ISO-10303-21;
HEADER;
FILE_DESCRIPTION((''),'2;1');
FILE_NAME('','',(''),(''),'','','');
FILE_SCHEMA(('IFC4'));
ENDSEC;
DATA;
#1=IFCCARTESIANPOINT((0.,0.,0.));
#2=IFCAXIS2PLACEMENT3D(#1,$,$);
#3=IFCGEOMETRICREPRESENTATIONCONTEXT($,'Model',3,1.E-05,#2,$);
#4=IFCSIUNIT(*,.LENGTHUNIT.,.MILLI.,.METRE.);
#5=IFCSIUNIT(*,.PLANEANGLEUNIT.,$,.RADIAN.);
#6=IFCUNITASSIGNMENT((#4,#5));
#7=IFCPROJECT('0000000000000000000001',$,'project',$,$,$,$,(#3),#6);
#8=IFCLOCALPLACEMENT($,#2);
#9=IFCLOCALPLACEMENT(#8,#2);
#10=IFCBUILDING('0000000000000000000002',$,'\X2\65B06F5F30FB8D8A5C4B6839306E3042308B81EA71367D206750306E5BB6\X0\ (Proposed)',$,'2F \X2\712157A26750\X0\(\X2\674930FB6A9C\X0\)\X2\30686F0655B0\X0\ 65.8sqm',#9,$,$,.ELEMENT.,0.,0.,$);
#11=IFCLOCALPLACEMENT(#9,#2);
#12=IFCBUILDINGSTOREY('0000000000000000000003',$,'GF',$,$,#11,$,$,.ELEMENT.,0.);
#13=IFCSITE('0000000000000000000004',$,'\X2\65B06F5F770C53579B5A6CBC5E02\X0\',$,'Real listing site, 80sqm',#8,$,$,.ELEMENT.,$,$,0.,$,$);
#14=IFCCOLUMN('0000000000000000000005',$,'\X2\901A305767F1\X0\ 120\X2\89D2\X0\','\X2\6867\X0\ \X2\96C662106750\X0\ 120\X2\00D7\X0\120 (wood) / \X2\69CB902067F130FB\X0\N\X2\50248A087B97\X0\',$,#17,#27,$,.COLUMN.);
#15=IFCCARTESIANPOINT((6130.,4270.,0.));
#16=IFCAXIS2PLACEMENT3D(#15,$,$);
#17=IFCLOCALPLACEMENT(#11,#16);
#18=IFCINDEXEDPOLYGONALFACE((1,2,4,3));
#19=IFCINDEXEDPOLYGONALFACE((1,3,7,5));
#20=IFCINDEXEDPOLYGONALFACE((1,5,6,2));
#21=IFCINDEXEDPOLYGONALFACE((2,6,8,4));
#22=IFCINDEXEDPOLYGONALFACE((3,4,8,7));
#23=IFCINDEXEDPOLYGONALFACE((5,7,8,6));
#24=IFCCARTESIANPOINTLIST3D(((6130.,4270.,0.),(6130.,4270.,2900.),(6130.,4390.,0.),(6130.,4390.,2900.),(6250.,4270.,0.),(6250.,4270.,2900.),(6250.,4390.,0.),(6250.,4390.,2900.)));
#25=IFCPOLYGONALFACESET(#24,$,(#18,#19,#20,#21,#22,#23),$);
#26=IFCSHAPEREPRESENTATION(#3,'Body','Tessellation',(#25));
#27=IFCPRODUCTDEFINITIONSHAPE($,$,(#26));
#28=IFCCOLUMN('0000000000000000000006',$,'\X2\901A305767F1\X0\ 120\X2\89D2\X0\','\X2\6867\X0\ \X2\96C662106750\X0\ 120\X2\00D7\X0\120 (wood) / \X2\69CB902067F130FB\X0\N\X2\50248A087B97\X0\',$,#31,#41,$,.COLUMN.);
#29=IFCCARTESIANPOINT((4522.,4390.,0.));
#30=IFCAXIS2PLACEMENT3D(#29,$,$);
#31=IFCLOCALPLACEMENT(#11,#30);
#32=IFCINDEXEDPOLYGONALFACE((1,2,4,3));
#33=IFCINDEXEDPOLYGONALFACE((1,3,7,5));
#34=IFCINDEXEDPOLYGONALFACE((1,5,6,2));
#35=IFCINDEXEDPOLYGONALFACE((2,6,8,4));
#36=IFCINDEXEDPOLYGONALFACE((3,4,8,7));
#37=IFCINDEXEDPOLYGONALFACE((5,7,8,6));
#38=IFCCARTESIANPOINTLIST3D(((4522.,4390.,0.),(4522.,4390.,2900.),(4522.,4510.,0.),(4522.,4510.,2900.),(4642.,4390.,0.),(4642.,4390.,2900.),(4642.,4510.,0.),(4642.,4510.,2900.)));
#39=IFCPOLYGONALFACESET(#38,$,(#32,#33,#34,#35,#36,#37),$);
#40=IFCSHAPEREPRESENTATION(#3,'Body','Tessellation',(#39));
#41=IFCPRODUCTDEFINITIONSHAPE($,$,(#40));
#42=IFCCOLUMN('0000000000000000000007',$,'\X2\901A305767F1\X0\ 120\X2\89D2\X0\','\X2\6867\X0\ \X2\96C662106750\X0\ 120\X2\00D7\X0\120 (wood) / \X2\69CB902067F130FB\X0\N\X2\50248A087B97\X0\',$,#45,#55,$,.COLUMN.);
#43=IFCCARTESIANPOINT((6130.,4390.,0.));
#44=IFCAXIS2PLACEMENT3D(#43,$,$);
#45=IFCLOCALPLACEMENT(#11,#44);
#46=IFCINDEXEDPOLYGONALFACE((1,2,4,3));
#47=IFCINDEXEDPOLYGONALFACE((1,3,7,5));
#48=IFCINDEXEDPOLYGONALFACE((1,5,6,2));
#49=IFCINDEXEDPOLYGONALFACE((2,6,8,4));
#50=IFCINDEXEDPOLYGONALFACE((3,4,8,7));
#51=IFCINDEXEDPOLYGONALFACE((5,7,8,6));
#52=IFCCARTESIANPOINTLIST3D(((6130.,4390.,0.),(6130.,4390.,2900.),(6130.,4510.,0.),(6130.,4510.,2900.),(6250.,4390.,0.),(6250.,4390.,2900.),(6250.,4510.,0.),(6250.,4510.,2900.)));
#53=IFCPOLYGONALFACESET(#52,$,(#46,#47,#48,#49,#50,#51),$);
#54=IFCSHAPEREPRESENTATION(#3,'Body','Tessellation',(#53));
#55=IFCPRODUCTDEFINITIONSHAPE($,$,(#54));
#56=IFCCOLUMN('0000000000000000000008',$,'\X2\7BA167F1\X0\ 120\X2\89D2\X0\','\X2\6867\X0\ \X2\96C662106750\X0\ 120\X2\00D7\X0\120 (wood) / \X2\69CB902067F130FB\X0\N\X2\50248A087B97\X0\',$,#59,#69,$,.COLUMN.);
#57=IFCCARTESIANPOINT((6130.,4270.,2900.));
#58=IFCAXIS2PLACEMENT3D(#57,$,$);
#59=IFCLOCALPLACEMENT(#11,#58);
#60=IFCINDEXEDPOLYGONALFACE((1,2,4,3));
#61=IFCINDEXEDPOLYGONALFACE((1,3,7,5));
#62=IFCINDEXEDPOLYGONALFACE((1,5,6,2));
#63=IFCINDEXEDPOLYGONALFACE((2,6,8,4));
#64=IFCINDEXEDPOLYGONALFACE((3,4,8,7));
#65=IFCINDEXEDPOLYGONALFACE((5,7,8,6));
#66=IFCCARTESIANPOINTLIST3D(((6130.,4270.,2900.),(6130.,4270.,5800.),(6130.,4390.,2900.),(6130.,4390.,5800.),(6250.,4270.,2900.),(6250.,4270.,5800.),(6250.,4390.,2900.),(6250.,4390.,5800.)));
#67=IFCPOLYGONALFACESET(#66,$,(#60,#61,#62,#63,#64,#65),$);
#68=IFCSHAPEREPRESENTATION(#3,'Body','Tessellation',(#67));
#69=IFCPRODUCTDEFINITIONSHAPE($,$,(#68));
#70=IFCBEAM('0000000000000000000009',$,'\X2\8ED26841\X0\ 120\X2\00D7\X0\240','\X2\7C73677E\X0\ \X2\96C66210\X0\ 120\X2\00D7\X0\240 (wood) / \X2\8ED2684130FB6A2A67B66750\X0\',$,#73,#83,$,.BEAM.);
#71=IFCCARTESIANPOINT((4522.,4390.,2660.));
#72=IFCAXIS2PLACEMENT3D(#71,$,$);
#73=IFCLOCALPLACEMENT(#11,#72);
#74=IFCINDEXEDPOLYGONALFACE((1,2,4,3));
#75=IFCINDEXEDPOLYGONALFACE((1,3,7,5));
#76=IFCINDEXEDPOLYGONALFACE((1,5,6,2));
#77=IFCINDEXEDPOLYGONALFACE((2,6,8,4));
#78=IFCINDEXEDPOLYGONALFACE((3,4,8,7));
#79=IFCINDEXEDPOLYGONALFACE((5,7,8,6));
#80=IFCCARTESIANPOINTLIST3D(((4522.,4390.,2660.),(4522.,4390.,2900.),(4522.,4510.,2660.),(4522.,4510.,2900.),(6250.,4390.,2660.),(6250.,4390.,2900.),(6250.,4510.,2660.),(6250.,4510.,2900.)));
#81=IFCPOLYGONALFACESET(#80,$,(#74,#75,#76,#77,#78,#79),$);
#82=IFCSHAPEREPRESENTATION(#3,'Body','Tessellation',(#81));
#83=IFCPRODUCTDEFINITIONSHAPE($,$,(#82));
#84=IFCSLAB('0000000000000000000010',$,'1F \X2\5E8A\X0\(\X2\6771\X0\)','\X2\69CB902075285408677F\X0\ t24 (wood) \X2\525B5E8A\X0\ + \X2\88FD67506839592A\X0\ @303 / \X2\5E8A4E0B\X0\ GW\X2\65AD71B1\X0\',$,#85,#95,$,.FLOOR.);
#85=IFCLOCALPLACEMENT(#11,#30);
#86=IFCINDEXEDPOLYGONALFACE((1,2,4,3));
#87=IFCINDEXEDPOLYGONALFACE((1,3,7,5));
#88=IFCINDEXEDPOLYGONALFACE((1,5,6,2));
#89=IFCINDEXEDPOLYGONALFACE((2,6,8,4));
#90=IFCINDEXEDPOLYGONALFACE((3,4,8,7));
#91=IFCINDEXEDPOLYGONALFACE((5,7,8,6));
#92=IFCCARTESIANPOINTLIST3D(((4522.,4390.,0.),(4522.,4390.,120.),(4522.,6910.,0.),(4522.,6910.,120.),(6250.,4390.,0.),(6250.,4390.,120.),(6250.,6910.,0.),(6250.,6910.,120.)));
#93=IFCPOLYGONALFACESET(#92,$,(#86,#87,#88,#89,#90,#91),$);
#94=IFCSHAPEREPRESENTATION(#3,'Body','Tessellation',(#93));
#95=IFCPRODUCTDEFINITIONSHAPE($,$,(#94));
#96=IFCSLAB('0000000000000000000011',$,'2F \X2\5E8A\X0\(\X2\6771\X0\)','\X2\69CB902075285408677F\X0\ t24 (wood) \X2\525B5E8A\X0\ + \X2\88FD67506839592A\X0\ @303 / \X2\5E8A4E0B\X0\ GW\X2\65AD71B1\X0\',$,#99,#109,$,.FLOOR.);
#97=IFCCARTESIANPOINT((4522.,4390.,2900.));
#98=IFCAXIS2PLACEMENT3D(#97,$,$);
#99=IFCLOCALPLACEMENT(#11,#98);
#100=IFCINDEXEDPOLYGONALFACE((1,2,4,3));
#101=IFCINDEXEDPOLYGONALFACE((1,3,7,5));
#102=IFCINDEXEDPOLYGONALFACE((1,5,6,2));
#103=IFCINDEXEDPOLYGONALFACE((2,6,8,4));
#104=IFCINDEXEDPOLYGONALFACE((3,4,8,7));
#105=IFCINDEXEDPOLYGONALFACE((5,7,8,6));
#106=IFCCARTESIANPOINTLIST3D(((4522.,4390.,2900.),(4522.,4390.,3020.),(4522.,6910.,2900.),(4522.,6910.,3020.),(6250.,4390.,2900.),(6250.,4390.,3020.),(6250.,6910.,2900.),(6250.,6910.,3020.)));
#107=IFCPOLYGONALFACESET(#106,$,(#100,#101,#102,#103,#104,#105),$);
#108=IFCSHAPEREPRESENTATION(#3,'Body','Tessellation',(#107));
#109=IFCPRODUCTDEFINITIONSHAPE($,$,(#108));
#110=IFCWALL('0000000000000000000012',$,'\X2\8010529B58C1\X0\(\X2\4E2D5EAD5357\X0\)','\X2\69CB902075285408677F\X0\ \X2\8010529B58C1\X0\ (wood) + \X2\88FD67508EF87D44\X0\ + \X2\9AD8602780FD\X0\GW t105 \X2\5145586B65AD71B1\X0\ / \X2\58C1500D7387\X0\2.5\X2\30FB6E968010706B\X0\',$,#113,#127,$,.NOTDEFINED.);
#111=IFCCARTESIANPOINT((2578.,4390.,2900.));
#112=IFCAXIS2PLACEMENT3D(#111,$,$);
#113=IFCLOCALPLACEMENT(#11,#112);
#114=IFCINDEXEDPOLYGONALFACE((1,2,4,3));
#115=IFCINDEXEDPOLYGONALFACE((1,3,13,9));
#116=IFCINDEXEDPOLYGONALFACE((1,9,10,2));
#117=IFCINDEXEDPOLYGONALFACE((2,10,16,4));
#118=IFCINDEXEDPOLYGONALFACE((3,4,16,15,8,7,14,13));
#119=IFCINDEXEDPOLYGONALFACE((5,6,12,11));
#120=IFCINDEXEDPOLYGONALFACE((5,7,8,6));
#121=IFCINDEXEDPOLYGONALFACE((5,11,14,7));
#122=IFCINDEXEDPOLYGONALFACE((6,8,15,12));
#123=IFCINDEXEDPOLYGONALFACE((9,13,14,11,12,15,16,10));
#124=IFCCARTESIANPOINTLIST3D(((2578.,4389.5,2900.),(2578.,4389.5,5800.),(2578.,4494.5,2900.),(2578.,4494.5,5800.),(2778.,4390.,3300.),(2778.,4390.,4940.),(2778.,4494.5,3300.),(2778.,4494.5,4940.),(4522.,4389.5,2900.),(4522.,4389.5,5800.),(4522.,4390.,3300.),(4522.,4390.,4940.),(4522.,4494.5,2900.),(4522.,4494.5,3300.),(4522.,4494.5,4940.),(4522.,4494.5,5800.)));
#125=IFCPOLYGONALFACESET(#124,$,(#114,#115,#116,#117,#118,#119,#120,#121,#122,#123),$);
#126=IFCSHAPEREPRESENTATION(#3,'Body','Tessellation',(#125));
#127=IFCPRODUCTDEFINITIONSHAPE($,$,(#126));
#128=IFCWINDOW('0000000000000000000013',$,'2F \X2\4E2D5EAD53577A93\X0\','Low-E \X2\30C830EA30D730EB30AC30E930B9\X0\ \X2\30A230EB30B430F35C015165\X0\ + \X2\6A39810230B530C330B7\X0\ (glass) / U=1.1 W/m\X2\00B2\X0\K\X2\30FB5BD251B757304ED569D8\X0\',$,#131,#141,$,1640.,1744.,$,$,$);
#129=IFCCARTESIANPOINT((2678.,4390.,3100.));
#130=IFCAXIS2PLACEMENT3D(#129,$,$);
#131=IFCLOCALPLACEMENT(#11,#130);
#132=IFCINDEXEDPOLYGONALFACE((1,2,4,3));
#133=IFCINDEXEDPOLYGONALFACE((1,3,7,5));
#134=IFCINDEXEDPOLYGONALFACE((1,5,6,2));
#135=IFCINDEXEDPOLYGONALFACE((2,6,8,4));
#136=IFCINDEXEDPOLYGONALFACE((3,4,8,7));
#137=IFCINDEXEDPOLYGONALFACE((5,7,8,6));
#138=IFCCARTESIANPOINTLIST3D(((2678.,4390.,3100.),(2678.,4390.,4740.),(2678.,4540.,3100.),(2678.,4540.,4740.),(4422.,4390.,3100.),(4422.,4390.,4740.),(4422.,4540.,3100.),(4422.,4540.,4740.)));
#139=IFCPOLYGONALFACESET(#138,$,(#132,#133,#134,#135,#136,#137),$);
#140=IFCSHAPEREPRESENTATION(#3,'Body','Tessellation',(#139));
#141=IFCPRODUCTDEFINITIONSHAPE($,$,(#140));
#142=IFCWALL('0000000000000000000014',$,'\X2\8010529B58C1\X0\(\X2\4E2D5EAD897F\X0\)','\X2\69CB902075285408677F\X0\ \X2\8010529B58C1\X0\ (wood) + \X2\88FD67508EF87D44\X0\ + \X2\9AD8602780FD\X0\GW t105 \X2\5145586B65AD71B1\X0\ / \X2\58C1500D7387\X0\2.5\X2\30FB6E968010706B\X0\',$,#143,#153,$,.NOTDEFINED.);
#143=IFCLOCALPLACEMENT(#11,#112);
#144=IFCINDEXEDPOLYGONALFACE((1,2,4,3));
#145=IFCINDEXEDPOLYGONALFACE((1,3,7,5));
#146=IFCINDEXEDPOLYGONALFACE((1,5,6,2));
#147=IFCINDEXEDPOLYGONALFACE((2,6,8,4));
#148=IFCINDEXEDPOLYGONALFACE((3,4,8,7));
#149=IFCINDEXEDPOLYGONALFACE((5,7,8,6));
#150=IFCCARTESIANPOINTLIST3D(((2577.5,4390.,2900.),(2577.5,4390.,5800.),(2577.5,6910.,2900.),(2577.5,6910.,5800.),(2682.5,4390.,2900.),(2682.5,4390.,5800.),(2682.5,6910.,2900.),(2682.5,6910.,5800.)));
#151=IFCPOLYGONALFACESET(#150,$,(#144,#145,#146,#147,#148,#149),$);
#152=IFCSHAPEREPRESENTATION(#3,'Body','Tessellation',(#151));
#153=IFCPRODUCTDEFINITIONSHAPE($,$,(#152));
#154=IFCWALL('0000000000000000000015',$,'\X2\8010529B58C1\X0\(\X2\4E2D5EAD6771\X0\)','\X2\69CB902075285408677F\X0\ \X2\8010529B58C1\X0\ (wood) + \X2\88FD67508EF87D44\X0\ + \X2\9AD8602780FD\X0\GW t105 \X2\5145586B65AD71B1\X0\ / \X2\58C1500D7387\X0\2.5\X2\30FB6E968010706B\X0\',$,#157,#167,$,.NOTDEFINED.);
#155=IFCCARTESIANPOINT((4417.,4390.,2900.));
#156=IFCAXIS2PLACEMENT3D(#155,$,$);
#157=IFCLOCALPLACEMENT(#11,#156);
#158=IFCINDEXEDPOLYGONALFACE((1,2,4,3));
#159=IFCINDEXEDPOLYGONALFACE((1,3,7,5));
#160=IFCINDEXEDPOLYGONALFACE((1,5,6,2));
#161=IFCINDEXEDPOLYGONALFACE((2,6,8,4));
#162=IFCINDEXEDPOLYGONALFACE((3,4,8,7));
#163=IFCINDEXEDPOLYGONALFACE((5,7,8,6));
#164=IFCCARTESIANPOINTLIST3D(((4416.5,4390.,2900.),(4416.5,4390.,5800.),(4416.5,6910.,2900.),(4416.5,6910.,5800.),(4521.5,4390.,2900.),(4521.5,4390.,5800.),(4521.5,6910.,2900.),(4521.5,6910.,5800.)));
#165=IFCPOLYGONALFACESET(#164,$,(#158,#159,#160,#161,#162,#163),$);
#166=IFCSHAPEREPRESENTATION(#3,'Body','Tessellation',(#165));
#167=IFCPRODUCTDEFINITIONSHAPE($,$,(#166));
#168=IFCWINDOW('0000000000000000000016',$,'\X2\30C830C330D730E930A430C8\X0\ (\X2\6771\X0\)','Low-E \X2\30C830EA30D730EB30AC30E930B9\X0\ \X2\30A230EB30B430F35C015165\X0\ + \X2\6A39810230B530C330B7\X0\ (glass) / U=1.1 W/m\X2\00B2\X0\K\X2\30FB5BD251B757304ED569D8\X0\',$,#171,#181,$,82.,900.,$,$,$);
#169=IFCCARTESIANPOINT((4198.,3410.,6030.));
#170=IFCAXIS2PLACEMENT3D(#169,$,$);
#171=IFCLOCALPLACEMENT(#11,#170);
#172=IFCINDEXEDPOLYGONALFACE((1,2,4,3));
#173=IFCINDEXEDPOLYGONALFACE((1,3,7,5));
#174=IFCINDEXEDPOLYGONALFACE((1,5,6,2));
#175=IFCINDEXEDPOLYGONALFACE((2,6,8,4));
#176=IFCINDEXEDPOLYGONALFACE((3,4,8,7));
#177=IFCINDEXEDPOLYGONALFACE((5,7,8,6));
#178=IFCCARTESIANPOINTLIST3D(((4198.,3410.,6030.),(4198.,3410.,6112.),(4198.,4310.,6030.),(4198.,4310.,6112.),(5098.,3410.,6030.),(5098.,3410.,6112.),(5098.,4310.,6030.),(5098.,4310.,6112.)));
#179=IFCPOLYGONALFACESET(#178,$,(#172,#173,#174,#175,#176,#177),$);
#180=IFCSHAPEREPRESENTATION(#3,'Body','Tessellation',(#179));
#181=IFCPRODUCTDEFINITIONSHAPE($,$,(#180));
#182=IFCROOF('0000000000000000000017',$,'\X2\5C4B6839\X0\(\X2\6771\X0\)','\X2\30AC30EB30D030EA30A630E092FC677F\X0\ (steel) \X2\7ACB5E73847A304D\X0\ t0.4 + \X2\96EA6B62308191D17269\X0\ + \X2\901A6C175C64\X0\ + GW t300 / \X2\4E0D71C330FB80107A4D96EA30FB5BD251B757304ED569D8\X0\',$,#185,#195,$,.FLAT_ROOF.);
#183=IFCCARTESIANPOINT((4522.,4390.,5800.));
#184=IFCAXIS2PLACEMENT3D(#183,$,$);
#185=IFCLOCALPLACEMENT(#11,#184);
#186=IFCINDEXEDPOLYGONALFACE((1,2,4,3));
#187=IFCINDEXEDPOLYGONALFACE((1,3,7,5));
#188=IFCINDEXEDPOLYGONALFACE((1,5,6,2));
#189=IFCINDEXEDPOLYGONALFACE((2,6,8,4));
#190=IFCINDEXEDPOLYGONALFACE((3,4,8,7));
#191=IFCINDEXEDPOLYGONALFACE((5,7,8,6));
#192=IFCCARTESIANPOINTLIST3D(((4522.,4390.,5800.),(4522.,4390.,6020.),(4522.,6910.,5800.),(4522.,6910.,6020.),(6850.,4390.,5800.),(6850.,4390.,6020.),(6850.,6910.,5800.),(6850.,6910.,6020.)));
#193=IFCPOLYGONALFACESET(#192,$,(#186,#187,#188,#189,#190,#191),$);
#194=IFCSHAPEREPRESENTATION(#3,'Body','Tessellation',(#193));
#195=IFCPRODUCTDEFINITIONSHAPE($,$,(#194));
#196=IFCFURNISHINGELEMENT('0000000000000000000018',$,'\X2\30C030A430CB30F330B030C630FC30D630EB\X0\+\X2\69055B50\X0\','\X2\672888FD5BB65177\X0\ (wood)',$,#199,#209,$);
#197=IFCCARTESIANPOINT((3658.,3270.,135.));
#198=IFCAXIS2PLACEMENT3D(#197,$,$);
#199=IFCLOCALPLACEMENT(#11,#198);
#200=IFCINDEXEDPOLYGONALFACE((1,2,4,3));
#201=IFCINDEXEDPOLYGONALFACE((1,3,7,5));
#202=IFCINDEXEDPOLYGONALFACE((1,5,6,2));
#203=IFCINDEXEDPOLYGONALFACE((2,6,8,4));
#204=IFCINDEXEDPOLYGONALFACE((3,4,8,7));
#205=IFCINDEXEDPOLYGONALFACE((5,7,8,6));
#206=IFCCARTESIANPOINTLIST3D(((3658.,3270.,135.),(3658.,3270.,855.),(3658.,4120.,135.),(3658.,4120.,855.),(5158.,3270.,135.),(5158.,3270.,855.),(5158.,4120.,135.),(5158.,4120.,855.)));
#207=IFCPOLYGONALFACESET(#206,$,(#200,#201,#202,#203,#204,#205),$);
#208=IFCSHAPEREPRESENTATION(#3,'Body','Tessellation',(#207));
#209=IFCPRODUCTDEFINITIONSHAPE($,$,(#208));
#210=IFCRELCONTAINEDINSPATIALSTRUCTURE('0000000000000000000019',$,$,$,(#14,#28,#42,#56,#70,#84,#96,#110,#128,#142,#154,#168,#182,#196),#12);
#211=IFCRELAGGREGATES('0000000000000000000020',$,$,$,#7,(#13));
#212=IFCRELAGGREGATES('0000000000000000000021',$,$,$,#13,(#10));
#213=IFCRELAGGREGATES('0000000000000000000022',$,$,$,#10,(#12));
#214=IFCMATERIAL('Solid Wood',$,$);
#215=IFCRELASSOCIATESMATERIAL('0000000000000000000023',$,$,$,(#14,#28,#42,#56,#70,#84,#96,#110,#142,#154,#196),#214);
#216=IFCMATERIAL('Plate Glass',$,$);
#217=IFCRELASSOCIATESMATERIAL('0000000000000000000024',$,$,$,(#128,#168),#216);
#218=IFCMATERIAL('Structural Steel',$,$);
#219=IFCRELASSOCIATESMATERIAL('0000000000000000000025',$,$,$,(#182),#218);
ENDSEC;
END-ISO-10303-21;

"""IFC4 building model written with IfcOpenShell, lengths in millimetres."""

from ifc_helpers import new_model, si_unit, frame, frame_2d, origin, place, context, project, spatial, rectangle, extrude, material, element, fill, save


model = new_model("IFC4")

# Units and contexts
model_context = context("Model", 3, precision=1e-05, world=origin())
ifc_project = project(units=[si_unit("LENGTHUNIT", "METRE", prefix="MILLI"), si_unit("PLANEANGLEUNIT", "RADIAN")], contexts=[model_context])

# Site, building, storey
site_placement = place(None, origin())
site = spatial("IfcSite", under=ifc_project, at=site_placement, Name="新潟県南魚沼市", ObjectType="Real listing site, 80sqm", CompositionType="ELEMENT", RefElevation=0.0)
building_placement = place(site_placement, origin())
building = spatial("IfcBuilding", under=site, at=building_placement, Name="新潟・越屋根のある自然素材の家 (Proposed)", ObjectType="2F 無垢材(杉・檜)と漆喰 65.8sqm", CompositionType="ELEMENT", ElevationOfRefHeight=0.0, ElevationOfTerrain=0.0)
storey_placement = place(building_placement, origin())
storey = spatial("IfcBuildingStorey", under=building, at=storey_placement, Name="GF", CompositionType="ELEMENT", Elevation=0.0)

# Columns
ifc_material_1 = material(Name="Solid Wood")
column_1_placement = place(storey_placement, frame((6130.0, 4270.0, 0.0)))
element("IfcColumn", 1, at=column_1_placement, inside=storey, material=ifc_material_1, Name="通し柱 120角", Description="桧 集成材 120×120 (wood) / 構造柱・N値計算", PredefinedType="COLUMN", context=model_context, shape_type="SweptSolid", body=[
    extrude(rectangle(XDim=120.0, YDim=120.0, at=frame_2d((60.0, 60.0))), frame((6130.0, 4270.0, 0.0)), (0.0, 0.0, 1.0), 2900.0),
])
column_2_placement = place(storey_placement, frame((4522.0, 4390.0, 0.0)))
element("IfcColumn", 2, at=column_2_placement, inside=storey, material=ifc_material_1, Name="通し柱 120角", Description="桧 集成材 120×120 (wood) / 構造柱・N値計算", PredefinedType="COLUMN", context=model_context, shape_type="SweptSolid", body=[
    extrude(rectangle(XDim=120.0, YDim=120.0, at=frame_2d((60.0, 60.0))), frame((4522.0, 4390.0, 0.0)), (0.0, 0.0, 1.0), 2900.0),
])
column_3_placement = place(storey_placement, frame((6130.0, 4390.0, 0.0)))
element("IfcColumn", 3, at=column_3_placement, inside=storey, material=ifc_material_1, Name="通し柱 120角", Description="桧 集成材 120×120 (wood) / 構造柱・N値計算", PredefinedType="COLUMN", context=model_context, shape_type="SweptSolid", body=[
    extrude(rectangle(XDim=120.0, YDim=120.0, at=frame_2d((60.0, 60.0))), frame((6130.0, 4390.0, 0.0)), (0.0, 0.0, 1.0), 2900.0),
])
column_4_placement = place(storey_placement, frame((6130.0, 4270.0, 2900.0)))
element("IfcColumn", 4, at=column_4_placement, inside=storey, material=ifc_material_1, Name="管柱 120角", Description="桧 集成材 120×120 (wood) / 構造柱・N値計算", PredefinedType="COLUMN", context=model_context, shape_type="SweptSolid", body=[
    extrude(rectangle(XDim=120.0, YDim=120.0, at=frame_2d((60.0, 60.0))), frame((6130.0, 4270.0, 2900.0)), (0.0, 0.0, 1.0), 2900.0),
])

# Beam
beam_1_placement = place(storey_placement, frame((4522.0, 4390.0, 2660.0)))
element("IfcBeam", 5, at=beam_1_placement, inside=storey, material=ifc_material_1, Name="軒桁 120×240", Description="米松 集成 120×240 (wood) / 軒桁・横架材", PredefinedType="BEAM", context=model_context, shape_type="SweptSolid", body=[
    extrude(rectangle(XDim=1728.0, YDim=120.0, at=frame_2d((864.0, 60.0))), frame((4522.0, 4390.0, 2660.0)), (0.0, 0.0, 1.0), 240.0),
])

# Slabs
slab_1_placement = place(storey_placement, frame((4522.0, 4390.0, 0.0)))
element("IfcSlab", 6, at=slab_1_placement, inside=storey, material=ifc_material_1, Name="1F 床(東)", Description="構造用合板 t24 (wood) 剛床 + 製材根太 @303 / 床下 GW断熱", PredefinedType="FLOOR", context=model_context, shape_type="SweptSolid", body=[
    extrude(rectangle(XDim=1728.0, YDim=2520.0, at=frame_2d((864.0, 1260.0))), frame((4522.0, 4390.0, 0.0)), (0.0, 0.0, 1.0), 120.0),
])
slab_2_placement = place(storey_placement, frame((4522.0, 4390.0, 2900.0)))
element("IfcSlab", 7, at=slab_2_placement, inside=storey, material=ifc_material_1, Name="2F 床(東)", Description="構造用合板 t24 (wood) 剛床 + 製材根太 @303 / 床下 GW断熱", PredefinedType="FLOOR", context=model_context, shape_type="SweptSolid", body=[
    extrude(rectangle(XDim=1728.0, YDim=2520.0, at=frame_2d((864.0, 1260.0))), frame((4522.0, 4390.0, 2900.0)), (0.0, 0.0, 1.0), 120.0),
])

# Wall, opening, window
wall_1_placement = place(storey_placement, frame((2578.0, 4390.0, 2900.0)))
wall_1 = element("IfcWall", 8, at=wall_1_placement, inside=storey, material=ifc_material_1, Name="耐力壁(中庭南)", Description="構造用合板 耐力壁 (wood) + 製材軸組 + 高性能GW t105 充填断熱 / 壁倍率2.5・準耐火", PredefinedType="NOTDEFINED", context=model_context, shape_type="SweptSolid", body=[
    extrude(rectangle(XDim=1944.0, YDim=105.0, at=frame_2d((972.0, 52.0))), frame((2578.0, 4390.0, 2900.0)), (0.0, 0.0, 1.0), 2900.0),
])
opening_placement = place(storey_placement, frame((2678.0, 4390.0, 3100.0)))
opening = element("IfcOpeningElement", 9, at=opening_placement, cuts=wall_1, PredefinedType="NOTDEFINED", context=model_context, shape_type="SweptSolid", body=[
    extrude(rectangle(XDim=1744.0, YDim=150.0, at=frame_2d((872.0, 75.0))), frame((2678.0, 4390.0, 3100.0)), (0.0, 0.0, 1.0), 1640.0),
])
ifc_material_2 = material(Name="Plate Glass")
window_1_placement = place(storey_placement, frame((2678.0, 4390.0, 3100.0)))
window_1 = element("IfcWindow", 10, at=window_1_placement, inside=storey, material=ifc_material_2, Name="2F 中庭南窓", Description="Low-E トリプルガラス アルゴン封入 + 樹脂サッシ (glass) / U=1.1 W/m²K・寒冷地仕様", OverallHeight=1640.0, OverallWidth=1744.0, context=model_context, shape_type="SweptSolid", body=[
    extrude(rectangle(XDim=1744.0, YDim=150.0, at=frame_2d((872.0, 75.0))), frame((2678.0, 4390.0, 3100.0)), (0.0, 0.0, 1.0), 1640.0),
])
fill(opening, window_1)

# Walls
wall_2_placement = place(storey_placement, frame((2578.0, 4390.0, 2900.0)))
element("IfcWall", 11, at=wall_2_placement, inside=storey, material=ifc_material_1, Name="耐力壁(中庭西)", Description="構造用合板 耐力壁 (wood) + 製材軸組 + 高性能GW t105 充填断熱 / 壁倍率2.5・準耐火", PredefinedType="NOTDEFINED", context=model_context, shape_type="SweptSolid", body=[
    extrude(rectangle(XDim=105.0, YDim=2520.0, at=frame_2d((52.0, 1260.0))), frame((2578.0, 4390.0, 2900.0)), (0.0, 0.0, 1.0), 2900.0),
])
wall_3_placement = place(storey_placement, frame((4417.0, 4390.0, 2900.0)))
element("IfcWall", 12, at=wall_3_placement, inside=storey, material=ifc_material_1, Name="耐力壁(中庭東)", Description="構造用合板 耐力壁 (wood) + 製材軸組 + 高性能GW t105 充填断熱 / 壁倍率2.5・準耐火", PredefinedType="NOTDEFINED", context=model_context, shape_type="SweptSolid", body=[
    extrude(rectangle(XDim=105.0, YDim=2520.0, at=frame_2d((52.0, 1260.0))), frame((4417.0, 4390.0, 2900.0)), (0.0, 0.0, 1.0), 2900.0),
])

# Window
window_2_placement = place(storey_placement, frame((4198.0, 3410.0, 6030.0)))
element("IfcWindow", 13, at=window_2_placement, inside=storey, material=ifc_material_2, Name="トップライト (東)", Description="Low-E トリプルガラス アルゴン封入 + 樹脂サッシ (glass) / U=1.1 W/m²K・寒冷地仕様", OverallHeight=82.0, OverallWidth=900.0, context=model_context, shape_type="SweptSolid", body=[
    extrude(rectangle(XDim=900.0, YDim=900.0, at=frame_2d((450.0, 450.0))), frame((4198.0, 3410.0, 6030.0)), (0.0, 0.0, 1.0), 82.0),
])

# Roof
ifc_material_3 = material(Name="Structural Steel")
for number, where, name in (
    (14, (4522.0, 4390.0, 5800.0), "屋根(東)"),
):
    element("IfcRoof", number, at=place(storey_placement, frame(where)), inside=storey, material=ifc_material_3, Name=name, Description="ガルバリウム鋼板 (steel) 立平葺き t0.4 + 雪止め金物 + 通気層 + GW t300 / 不燃・耐積雪・寒冷地仕様", PredefinedType="FLAT_ROOF", context=model_context, shape_type="SweptSolid", body=[
        extrude(rectangle(XDim=2328.0, YDim=2520.0, at=frame_2d((1164.0, 1260.0))), frame((4522.0, 4390.0, 5800.0)), (0.0, 0.0, 1.0), 220.0),
    ])

# Furnishing element
furnishing_1_placement = place(storey_placement, frame((3658.0, 3270.0, 135.0)))
element("IfcFurnishingElement", 15, at=furnishing_1_placement, inside=storey, material=ifc_material_1, Name="ダイニングテーブル+椅子", Description="木製家具 (wood)", context=model_context, shape_type="SweptSolid", body=[
    extrude(rectangle(XDim=1500.0, YDim=850.0, at=frame_2d((750.0, 425.0))), frame((3658.0, 3270.0, 135.0)), (0.0, 0.0, 1.0), 720.0),
])

save(model, "model.ifc")
